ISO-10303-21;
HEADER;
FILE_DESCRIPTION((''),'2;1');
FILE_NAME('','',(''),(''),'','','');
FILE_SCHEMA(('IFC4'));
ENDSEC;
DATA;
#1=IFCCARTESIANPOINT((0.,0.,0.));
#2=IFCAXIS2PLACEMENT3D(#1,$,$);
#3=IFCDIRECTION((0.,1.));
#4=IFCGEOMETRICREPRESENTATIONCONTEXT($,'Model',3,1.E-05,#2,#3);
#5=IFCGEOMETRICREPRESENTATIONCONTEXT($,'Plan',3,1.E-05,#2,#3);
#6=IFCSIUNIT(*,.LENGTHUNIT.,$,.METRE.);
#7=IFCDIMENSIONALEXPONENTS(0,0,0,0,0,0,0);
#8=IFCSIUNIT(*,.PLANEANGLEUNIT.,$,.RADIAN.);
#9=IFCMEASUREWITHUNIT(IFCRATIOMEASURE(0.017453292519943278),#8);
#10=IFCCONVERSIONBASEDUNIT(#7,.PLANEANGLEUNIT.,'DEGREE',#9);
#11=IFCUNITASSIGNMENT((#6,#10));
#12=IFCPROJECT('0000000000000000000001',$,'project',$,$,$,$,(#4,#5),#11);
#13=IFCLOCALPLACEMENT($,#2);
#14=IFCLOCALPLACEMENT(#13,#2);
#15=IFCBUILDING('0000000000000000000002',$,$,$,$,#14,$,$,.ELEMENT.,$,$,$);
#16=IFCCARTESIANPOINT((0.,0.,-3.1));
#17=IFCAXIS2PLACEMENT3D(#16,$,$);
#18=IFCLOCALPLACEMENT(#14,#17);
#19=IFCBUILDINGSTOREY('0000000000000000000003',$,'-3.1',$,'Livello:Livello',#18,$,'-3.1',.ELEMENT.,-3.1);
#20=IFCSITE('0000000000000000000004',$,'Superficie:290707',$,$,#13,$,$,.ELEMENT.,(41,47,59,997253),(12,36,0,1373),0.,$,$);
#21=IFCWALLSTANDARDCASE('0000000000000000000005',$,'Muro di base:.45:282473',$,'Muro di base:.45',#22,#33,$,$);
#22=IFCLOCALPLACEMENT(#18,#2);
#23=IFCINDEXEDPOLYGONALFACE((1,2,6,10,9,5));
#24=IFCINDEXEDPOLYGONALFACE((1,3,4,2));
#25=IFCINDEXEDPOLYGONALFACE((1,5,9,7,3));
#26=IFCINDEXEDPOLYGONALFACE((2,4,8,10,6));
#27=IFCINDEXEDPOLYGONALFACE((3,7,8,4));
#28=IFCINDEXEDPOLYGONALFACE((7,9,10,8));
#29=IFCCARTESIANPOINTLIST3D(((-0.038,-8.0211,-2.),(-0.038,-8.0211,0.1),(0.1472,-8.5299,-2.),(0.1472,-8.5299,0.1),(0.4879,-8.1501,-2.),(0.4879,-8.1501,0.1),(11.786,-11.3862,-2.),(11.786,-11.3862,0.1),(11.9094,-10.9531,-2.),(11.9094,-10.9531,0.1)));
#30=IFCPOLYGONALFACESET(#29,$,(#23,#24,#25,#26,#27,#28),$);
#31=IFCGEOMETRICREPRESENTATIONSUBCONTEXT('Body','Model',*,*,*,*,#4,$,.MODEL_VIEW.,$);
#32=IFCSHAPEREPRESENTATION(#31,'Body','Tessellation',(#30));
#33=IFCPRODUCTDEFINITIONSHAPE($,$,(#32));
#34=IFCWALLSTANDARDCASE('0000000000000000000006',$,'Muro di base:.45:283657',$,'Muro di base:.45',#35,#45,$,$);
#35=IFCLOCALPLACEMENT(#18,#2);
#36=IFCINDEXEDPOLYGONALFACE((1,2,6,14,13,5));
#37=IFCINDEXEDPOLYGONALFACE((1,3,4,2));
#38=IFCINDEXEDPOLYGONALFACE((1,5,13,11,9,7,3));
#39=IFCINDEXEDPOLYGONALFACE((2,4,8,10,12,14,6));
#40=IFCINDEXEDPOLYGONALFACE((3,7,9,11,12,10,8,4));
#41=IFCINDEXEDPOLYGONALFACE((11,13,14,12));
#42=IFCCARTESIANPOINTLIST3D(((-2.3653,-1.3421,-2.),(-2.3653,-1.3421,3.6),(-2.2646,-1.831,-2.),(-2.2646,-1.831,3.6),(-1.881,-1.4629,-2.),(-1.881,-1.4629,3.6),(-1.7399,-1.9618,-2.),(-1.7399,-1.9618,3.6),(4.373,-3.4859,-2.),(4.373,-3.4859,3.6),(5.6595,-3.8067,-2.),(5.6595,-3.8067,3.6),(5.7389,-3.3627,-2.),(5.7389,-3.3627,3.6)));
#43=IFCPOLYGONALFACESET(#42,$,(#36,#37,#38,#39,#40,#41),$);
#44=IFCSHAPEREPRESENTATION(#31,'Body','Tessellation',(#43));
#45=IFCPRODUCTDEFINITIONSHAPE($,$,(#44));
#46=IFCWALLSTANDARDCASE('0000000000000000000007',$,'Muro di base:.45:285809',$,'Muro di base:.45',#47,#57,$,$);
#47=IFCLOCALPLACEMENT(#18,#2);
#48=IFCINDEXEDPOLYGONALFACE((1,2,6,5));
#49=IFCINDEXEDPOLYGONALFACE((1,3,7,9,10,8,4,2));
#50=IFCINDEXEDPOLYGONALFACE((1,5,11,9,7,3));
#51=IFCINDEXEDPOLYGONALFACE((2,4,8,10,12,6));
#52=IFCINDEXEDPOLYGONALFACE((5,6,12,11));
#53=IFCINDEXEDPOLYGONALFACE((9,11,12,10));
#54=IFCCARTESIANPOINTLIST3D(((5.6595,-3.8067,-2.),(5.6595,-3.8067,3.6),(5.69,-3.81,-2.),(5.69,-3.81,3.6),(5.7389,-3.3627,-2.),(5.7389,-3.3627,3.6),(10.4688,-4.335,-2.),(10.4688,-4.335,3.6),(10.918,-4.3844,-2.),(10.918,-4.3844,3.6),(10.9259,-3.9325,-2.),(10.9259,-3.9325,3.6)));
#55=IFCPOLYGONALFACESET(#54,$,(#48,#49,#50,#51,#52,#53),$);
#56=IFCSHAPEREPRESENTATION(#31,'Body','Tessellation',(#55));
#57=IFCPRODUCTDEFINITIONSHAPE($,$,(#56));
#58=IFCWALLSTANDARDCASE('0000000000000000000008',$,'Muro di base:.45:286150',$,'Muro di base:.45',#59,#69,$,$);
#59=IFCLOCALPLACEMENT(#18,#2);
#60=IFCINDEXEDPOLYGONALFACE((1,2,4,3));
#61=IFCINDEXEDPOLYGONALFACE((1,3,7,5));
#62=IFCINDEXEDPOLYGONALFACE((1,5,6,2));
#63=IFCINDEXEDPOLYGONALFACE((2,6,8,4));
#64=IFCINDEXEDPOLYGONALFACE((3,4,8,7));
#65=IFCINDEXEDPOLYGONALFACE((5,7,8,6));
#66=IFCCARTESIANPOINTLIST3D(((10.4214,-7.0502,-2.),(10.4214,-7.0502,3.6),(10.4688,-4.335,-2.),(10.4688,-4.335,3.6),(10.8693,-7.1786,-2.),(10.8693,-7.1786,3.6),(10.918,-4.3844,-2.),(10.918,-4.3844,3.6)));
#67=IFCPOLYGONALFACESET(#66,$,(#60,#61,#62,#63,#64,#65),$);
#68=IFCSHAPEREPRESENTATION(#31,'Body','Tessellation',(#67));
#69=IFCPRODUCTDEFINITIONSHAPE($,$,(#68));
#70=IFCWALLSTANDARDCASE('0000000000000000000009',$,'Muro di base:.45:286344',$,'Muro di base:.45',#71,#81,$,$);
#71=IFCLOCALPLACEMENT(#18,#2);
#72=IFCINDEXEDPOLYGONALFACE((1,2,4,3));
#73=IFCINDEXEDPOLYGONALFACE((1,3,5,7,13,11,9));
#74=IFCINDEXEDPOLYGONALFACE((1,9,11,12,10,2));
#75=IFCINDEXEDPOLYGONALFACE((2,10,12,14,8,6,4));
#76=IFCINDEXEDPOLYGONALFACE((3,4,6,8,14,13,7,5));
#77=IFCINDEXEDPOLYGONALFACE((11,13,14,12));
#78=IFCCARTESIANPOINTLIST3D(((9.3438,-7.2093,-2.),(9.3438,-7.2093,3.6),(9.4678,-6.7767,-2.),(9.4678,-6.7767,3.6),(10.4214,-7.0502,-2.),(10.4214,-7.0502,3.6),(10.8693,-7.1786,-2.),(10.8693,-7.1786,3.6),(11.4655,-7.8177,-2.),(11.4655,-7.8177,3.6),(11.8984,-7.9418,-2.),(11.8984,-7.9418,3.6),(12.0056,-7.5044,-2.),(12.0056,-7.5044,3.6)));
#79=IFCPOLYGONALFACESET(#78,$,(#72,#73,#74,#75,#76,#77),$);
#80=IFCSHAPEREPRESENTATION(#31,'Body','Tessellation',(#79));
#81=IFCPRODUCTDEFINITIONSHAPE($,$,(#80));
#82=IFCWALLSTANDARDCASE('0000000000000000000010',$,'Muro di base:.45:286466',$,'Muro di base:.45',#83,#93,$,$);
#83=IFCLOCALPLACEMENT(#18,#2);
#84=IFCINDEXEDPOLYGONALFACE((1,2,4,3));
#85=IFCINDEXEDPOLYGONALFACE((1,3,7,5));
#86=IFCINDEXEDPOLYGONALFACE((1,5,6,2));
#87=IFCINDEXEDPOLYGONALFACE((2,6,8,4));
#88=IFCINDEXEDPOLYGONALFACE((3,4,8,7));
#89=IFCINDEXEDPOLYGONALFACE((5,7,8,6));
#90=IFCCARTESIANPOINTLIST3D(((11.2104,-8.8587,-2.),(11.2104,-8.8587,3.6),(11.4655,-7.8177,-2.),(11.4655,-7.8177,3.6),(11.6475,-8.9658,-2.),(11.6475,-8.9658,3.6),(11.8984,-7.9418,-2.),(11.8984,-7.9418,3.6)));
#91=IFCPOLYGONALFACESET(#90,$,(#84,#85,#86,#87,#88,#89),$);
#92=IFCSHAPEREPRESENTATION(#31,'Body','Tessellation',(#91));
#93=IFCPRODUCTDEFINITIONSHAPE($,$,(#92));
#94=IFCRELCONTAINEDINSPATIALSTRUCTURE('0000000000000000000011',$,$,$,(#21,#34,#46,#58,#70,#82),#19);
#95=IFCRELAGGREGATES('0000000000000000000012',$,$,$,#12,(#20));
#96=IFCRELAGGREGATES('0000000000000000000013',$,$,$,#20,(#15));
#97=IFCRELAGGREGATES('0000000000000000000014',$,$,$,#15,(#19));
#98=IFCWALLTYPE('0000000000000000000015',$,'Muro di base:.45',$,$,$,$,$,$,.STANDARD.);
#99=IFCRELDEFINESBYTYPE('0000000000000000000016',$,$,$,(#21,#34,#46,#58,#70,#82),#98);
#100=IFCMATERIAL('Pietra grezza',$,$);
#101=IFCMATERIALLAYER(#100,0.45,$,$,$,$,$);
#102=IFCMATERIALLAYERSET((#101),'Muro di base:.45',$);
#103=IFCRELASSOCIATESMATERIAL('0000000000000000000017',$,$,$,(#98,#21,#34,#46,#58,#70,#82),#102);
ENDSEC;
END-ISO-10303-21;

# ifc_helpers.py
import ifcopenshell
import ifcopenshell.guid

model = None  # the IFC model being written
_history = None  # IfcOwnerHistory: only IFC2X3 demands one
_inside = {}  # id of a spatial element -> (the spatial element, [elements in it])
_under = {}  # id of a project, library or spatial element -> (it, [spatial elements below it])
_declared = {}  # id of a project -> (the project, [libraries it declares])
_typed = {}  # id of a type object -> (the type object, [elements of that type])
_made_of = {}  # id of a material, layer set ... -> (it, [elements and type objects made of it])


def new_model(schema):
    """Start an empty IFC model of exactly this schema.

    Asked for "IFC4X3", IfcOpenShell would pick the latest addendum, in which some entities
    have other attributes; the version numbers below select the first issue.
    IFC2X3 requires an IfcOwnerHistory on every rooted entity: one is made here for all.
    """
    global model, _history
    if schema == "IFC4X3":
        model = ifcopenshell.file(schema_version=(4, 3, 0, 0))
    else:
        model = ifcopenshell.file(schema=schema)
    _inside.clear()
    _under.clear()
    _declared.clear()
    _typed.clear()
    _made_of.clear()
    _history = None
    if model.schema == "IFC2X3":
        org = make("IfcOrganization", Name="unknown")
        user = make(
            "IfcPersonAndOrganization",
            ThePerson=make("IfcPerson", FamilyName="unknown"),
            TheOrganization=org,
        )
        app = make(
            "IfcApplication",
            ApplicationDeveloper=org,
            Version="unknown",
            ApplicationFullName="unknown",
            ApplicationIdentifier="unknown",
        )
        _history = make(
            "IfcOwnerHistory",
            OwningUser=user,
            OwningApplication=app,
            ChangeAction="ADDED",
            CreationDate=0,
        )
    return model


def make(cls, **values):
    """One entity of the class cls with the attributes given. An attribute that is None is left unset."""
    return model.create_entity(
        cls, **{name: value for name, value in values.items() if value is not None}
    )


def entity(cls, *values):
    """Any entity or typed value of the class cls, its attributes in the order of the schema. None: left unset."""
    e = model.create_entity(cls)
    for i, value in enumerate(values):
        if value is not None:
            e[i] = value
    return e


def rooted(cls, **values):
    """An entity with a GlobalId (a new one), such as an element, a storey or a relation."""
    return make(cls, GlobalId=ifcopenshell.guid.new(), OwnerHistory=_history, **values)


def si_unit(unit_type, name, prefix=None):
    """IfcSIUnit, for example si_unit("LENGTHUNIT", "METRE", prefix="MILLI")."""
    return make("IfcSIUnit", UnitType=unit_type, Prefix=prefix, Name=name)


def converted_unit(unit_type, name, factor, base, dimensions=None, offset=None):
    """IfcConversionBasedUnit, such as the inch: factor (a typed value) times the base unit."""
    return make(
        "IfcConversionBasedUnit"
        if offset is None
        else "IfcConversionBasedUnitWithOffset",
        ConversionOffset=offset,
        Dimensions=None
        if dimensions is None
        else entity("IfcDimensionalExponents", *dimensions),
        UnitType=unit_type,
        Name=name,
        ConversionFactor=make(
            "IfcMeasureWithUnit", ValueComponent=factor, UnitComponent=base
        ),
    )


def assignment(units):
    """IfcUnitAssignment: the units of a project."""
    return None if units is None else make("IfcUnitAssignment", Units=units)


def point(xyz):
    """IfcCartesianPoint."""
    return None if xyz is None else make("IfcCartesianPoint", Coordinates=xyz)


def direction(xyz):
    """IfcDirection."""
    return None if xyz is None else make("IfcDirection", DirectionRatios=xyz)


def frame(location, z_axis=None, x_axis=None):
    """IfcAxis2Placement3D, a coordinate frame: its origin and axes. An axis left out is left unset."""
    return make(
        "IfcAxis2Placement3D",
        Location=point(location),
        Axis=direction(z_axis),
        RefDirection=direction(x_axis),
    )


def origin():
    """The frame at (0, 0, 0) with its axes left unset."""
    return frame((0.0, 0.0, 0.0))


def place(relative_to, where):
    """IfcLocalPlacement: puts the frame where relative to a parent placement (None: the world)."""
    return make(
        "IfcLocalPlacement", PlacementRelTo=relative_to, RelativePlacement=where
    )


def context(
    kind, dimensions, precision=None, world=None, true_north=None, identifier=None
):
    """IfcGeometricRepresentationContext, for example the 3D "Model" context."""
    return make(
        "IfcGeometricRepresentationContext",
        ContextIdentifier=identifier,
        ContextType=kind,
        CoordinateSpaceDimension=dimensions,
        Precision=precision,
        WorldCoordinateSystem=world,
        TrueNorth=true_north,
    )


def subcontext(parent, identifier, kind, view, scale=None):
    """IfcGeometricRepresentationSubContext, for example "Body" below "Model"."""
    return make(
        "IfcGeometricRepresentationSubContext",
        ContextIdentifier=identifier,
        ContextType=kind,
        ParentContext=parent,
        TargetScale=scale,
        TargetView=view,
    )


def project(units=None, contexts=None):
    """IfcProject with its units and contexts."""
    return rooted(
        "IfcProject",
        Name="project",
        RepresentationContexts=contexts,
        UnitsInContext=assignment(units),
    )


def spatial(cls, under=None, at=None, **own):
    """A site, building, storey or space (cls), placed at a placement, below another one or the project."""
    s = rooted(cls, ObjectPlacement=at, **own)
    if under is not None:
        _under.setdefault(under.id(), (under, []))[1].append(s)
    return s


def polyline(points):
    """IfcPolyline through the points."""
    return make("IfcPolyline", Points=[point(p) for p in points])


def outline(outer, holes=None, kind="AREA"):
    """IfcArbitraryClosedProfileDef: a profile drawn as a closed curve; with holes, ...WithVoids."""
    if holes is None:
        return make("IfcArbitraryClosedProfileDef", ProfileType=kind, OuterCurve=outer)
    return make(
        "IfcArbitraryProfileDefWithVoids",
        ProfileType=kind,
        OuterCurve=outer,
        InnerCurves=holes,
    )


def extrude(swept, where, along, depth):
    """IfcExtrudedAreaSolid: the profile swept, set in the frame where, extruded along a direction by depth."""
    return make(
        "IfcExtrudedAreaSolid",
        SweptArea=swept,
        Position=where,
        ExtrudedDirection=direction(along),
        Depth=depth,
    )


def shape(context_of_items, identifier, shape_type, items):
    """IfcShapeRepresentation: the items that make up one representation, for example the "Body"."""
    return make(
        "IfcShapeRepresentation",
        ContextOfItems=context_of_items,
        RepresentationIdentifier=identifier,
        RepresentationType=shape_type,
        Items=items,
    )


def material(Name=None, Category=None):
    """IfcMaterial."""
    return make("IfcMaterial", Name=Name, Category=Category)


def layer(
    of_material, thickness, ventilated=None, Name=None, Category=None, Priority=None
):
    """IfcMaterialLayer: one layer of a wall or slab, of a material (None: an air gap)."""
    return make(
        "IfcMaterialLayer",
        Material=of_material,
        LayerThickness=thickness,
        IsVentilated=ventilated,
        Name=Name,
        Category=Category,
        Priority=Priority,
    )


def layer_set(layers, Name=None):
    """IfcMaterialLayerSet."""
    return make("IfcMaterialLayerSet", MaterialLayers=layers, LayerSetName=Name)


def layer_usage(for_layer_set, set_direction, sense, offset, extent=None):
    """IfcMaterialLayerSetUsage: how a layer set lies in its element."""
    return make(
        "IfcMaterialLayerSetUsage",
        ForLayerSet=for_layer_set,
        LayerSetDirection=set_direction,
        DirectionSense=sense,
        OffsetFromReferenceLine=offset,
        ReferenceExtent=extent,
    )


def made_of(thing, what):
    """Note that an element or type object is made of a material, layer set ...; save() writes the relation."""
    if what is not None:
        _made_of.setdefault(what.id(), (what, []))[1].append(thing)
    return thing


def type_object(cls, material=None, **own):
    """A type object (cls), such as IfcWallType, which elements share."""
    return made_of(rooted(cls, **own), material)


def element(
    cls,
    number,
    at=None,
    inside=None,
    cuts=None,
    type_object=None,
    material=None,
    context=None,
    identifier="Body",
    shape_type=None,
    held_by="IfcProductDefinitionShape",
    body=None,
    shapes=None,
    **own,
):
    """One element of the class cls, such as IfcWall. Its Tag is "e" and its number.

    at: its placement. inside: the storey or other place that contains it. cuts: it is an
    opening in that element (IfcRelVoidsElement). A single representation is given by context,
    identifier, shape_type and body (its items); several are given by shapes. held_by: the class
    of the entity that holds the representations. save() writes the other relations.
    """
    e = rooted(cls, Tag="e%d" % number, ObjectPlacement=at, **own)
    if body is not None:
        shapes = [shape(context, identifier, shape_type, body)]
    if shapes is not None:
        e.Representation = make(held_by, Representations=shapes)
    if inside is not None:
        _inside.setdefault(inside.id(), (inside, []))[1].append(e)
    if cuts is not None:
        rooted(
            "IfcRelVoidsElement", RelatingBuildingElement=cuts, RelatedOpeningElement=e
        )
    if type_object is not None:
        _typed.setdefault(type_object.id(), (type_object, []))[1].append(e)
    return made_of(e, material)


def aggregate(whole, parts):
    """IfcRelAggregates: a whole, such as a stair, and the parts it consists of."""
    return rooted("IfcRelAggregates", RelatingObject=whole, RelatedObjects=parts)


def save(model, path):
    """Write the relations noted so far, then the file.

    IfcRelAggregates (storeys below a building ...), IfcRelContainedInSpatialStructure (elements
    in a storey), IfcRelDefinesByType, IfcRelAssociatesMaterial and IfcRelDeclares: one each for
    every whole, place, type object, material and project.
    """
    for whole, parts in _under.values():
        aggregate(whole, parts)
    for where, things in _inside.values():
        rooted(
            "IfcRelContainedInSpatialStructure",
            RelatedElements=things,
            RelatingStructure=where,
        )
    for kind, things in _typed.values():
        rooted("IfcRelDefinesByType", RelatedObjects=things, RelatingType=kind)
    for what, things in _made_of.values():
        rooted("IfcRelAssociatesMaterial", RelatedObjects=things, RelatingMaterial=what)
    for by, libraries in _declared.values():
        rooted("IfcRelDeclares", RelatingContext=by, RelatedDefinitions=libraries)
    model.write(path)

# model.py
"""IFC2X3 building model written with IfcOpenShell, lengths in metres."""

from ifc_helpers import new_model, entity, si_unit, converted_unit, direction, frame, origin, place, context, subcontext, project, spatial, polyline, outline, extrude, material, layer, layer_set, layer_usage, type_object, element, save


model = new_model("IFC2X3")

# Units and contexts
model_context = context("Model", 3, precision=1e-05, world=origin(), true_north=direction((0.0, 1.0)))
plan_context = context("Plan", 3, precision=1e-05, world=origin(), true_north=direction((0.0, 1.0)))
body_context = subcontext(model_context, "Body", "Model", "MODEL_VIEW")
ifc_project = project(units=[si_unit("LENGTHUNIT", "METRE"), converted_unit("PLANEANGLEUNIT", "DEGREE", entity("IfcRatioMeasure", 0.017453292519943278), si_unit("PLANEANGLEUNIT", "RADIAN"), dimensions=[0, 0, 0, 0, 0, 0, 0])], contexts=[model_context, plan_context])

# Site, building, storey
site_placement = place(None, origin())
site = spatial("IfcSite", under=ifc_project, at=site_placement, Name="Superficie:290707", CompositionType="ELEMENT", RefLatitude=(41, 47, 59, 997253), RefLongitude=(12, 36, 0, 1373), RefElevation=0.0)
building_placement = place(site_placement, origin())
building = spatial("IfcBuilding", under=site, at=building_placement, CompositionType="ELEMENT")
storey_placement = place(building_placement, frame((0.0, 0.0, -3.1)))
storey = spatial("IfcBuildingStorey", under=building, at=storey_placement, Name="-3.1", ObjectType="Livello:Livello", LongName="-3.1", CompositionType="ELEMENT", Elevation=-3.1)

# Shared definitions
ifc_material_1 = material(Name="Pietra grezza")

# Walls
ifc_layer_1 = layer(ifc_material_1, 0.45)
ifc_layer_set_1 = layer_set([ifc_layer_1], Name="Muro di base:.45")
ifc_layer_usage_1 = layer_usage(ifc_layer_set_1, "AXIS2", "NEGATIVE", 0.225)
wall_type_1 = type_object("IfcWallType", Name="Muro di base:.45", PredefinedType="STANDARD", material=ifc_layer_set_1)
wall_1_placement = place(storey_placement, frame((11.8558, -11.1717, -2.0), z_axis=(0.0, 0.0, 1.0), x_axis=(-0.971181, 0.238343, 0.0)))
element("IfcWallStandardCase", 1, at=wall_1_placement, inside=storey, type_object=wall_type_1, material=ifc_layer_usage_1, Name="Muro di base:.45:282473", ObjectType="Muro di base:.45", context=body_context, shape_type="SweptSolid", body=[
    extrude(outline(polyline([(12.3019, -0.225), (12.0008, 0.225), (0.0166, 0.225), (0.0, -0.225), (11.7605, -0.225), (12.3019, -0.225)])), origin(), (0.0, 0.0, 1.0), 2.1),
])
wall_2_placement = place(storey_placement, frame((5.714, -3.5884, -2.0), z_axis=(0.0, 0.0, 1.0), x_axis=(-0.970296, 0.241922, 0.0)))
element("IfcWallStandardCase", 2, at=wall_2_placement, inside=storey, type_object=wall_type_1, material=ifc_layer_usage_1, Name="Muro di base:.45:283657", ObjectType="Muro di base:.45", context=body_context, shape_type="SweptSolid", body=[
    extrude(outline(polyline([(8.3827, -0.225), (8.1668, 0.225), (7.6259, 0.225), (1.3259, 0.225), (0.0, 0.225), (0.0304, -0.225), (7.8836, -0.225), (8.3827, -0.225)])), origin(), (0.0, 0.0, 1.0), 5.6),
])
wall_3_placement = place(storey_placement, frame((5.6841, -3.583, -2.0), z_axis=(0.0, 0.0, 1.0), x_axis=(0.99402, -0.109198, 0.0)))
element("IfcWallStandardCase", 3, at=wall_3_placement, inside=storey, type_object=wall_type_1, material=ifc_layer_usage_1, Name="Muro di base:.45:285809", ObjectType="Muro di base:.45", context=body_context, shape_type="SweptSolid", body=[
    extrude(outline(polyline([(5.2901, -0.225), (5.2486, 0.225), (0.0304, 0.225), (0.0, -0.225), (0.0306, -0.225), (4.8382, -0.225), (5.2901, -0.225)])), origin(), (0.0, 0.0, 1.0), 5.6),
])
wall_4_placement = place(storey_placement, frame((10.6938, -4.3389, -2.0), z_axis=(0.0, 0.0, 1.0), x_axis=(-0.017452, -0.999848, 0.0)))
element("IfcWallStandardCase", 4, at=wall_4_placement, inside=storey, type_object=wall_type_1, material=ifc_layer_usage_1, Name="Muro di base:.45:286150", ObjectType="Muro di base:.45", context=body_context, shape_type="SweptSolid", body=[
    extrude(outline(polyline([(2.7156, -0.225), (2.8361, 0.225), (0.0415, 0.225), (0.0, -0.225), (2.7156, -0.225)])), origin(), (0.0, 0.0, 1.0), 5.6),
])
ifc_layer_usage_2 = layer_usage(ifc_layer_set_1, "AXIS2", "POSITIVE", -0.225)
wall_5_placement = place(storey_placement, frame((9.4058, -6.993, -2.0), z_axis=(0.0, 0.0, 1.0), x_axis=(0.961262, -0.275637, 0.0)))
element("IfcWallStandardCase", 5, at=wall_5_placement, inside=storey, type_object=wall_type_1, material=ifc_layer_usage_2, Name="Muro di base:.45:286344", ObjectType="Muro di base:.45", context=body_context, shape_type="SweptSolid", body=[
    extrude(outline(polyline([(2.6576, -0.225), (2.64, 0.225), (1.4579, 0.225), (0.992, 0.225), (0.0, 0.225), (0.0, -0.225), (2.2072, -0.225), (2.6576, -0.225)])), origin(), (0.0, 0.0, 1.0), 5.6),
])
wall_6_placement = place(storey_placement, frame((11.684, -7.8712, -2.0), z_axis=(0.0, 0.0, 1.0), x_axis=(-0.237955, -0.971276, 0.0)))
element("IfcWallStandardCase", 6, at=wall_6_placement, inside=storey, type_object=wall_type_1, material=ifc_layer_usage_2, Name="Muro di base:.45:286466", ObjectType="Muro di base:.45", context=body_context, shape_type="SweptSolid", body=[
    extrude(outline(polyline([(1.0718, -0.225), (1.0718, 0.225), (0.0176, 0.225), (0.0, -0.225), (1.0718, -0.225)])), origin(), (0.0, 0.0, 1.0), 5.6),
])

save(model, "model.ifc")
